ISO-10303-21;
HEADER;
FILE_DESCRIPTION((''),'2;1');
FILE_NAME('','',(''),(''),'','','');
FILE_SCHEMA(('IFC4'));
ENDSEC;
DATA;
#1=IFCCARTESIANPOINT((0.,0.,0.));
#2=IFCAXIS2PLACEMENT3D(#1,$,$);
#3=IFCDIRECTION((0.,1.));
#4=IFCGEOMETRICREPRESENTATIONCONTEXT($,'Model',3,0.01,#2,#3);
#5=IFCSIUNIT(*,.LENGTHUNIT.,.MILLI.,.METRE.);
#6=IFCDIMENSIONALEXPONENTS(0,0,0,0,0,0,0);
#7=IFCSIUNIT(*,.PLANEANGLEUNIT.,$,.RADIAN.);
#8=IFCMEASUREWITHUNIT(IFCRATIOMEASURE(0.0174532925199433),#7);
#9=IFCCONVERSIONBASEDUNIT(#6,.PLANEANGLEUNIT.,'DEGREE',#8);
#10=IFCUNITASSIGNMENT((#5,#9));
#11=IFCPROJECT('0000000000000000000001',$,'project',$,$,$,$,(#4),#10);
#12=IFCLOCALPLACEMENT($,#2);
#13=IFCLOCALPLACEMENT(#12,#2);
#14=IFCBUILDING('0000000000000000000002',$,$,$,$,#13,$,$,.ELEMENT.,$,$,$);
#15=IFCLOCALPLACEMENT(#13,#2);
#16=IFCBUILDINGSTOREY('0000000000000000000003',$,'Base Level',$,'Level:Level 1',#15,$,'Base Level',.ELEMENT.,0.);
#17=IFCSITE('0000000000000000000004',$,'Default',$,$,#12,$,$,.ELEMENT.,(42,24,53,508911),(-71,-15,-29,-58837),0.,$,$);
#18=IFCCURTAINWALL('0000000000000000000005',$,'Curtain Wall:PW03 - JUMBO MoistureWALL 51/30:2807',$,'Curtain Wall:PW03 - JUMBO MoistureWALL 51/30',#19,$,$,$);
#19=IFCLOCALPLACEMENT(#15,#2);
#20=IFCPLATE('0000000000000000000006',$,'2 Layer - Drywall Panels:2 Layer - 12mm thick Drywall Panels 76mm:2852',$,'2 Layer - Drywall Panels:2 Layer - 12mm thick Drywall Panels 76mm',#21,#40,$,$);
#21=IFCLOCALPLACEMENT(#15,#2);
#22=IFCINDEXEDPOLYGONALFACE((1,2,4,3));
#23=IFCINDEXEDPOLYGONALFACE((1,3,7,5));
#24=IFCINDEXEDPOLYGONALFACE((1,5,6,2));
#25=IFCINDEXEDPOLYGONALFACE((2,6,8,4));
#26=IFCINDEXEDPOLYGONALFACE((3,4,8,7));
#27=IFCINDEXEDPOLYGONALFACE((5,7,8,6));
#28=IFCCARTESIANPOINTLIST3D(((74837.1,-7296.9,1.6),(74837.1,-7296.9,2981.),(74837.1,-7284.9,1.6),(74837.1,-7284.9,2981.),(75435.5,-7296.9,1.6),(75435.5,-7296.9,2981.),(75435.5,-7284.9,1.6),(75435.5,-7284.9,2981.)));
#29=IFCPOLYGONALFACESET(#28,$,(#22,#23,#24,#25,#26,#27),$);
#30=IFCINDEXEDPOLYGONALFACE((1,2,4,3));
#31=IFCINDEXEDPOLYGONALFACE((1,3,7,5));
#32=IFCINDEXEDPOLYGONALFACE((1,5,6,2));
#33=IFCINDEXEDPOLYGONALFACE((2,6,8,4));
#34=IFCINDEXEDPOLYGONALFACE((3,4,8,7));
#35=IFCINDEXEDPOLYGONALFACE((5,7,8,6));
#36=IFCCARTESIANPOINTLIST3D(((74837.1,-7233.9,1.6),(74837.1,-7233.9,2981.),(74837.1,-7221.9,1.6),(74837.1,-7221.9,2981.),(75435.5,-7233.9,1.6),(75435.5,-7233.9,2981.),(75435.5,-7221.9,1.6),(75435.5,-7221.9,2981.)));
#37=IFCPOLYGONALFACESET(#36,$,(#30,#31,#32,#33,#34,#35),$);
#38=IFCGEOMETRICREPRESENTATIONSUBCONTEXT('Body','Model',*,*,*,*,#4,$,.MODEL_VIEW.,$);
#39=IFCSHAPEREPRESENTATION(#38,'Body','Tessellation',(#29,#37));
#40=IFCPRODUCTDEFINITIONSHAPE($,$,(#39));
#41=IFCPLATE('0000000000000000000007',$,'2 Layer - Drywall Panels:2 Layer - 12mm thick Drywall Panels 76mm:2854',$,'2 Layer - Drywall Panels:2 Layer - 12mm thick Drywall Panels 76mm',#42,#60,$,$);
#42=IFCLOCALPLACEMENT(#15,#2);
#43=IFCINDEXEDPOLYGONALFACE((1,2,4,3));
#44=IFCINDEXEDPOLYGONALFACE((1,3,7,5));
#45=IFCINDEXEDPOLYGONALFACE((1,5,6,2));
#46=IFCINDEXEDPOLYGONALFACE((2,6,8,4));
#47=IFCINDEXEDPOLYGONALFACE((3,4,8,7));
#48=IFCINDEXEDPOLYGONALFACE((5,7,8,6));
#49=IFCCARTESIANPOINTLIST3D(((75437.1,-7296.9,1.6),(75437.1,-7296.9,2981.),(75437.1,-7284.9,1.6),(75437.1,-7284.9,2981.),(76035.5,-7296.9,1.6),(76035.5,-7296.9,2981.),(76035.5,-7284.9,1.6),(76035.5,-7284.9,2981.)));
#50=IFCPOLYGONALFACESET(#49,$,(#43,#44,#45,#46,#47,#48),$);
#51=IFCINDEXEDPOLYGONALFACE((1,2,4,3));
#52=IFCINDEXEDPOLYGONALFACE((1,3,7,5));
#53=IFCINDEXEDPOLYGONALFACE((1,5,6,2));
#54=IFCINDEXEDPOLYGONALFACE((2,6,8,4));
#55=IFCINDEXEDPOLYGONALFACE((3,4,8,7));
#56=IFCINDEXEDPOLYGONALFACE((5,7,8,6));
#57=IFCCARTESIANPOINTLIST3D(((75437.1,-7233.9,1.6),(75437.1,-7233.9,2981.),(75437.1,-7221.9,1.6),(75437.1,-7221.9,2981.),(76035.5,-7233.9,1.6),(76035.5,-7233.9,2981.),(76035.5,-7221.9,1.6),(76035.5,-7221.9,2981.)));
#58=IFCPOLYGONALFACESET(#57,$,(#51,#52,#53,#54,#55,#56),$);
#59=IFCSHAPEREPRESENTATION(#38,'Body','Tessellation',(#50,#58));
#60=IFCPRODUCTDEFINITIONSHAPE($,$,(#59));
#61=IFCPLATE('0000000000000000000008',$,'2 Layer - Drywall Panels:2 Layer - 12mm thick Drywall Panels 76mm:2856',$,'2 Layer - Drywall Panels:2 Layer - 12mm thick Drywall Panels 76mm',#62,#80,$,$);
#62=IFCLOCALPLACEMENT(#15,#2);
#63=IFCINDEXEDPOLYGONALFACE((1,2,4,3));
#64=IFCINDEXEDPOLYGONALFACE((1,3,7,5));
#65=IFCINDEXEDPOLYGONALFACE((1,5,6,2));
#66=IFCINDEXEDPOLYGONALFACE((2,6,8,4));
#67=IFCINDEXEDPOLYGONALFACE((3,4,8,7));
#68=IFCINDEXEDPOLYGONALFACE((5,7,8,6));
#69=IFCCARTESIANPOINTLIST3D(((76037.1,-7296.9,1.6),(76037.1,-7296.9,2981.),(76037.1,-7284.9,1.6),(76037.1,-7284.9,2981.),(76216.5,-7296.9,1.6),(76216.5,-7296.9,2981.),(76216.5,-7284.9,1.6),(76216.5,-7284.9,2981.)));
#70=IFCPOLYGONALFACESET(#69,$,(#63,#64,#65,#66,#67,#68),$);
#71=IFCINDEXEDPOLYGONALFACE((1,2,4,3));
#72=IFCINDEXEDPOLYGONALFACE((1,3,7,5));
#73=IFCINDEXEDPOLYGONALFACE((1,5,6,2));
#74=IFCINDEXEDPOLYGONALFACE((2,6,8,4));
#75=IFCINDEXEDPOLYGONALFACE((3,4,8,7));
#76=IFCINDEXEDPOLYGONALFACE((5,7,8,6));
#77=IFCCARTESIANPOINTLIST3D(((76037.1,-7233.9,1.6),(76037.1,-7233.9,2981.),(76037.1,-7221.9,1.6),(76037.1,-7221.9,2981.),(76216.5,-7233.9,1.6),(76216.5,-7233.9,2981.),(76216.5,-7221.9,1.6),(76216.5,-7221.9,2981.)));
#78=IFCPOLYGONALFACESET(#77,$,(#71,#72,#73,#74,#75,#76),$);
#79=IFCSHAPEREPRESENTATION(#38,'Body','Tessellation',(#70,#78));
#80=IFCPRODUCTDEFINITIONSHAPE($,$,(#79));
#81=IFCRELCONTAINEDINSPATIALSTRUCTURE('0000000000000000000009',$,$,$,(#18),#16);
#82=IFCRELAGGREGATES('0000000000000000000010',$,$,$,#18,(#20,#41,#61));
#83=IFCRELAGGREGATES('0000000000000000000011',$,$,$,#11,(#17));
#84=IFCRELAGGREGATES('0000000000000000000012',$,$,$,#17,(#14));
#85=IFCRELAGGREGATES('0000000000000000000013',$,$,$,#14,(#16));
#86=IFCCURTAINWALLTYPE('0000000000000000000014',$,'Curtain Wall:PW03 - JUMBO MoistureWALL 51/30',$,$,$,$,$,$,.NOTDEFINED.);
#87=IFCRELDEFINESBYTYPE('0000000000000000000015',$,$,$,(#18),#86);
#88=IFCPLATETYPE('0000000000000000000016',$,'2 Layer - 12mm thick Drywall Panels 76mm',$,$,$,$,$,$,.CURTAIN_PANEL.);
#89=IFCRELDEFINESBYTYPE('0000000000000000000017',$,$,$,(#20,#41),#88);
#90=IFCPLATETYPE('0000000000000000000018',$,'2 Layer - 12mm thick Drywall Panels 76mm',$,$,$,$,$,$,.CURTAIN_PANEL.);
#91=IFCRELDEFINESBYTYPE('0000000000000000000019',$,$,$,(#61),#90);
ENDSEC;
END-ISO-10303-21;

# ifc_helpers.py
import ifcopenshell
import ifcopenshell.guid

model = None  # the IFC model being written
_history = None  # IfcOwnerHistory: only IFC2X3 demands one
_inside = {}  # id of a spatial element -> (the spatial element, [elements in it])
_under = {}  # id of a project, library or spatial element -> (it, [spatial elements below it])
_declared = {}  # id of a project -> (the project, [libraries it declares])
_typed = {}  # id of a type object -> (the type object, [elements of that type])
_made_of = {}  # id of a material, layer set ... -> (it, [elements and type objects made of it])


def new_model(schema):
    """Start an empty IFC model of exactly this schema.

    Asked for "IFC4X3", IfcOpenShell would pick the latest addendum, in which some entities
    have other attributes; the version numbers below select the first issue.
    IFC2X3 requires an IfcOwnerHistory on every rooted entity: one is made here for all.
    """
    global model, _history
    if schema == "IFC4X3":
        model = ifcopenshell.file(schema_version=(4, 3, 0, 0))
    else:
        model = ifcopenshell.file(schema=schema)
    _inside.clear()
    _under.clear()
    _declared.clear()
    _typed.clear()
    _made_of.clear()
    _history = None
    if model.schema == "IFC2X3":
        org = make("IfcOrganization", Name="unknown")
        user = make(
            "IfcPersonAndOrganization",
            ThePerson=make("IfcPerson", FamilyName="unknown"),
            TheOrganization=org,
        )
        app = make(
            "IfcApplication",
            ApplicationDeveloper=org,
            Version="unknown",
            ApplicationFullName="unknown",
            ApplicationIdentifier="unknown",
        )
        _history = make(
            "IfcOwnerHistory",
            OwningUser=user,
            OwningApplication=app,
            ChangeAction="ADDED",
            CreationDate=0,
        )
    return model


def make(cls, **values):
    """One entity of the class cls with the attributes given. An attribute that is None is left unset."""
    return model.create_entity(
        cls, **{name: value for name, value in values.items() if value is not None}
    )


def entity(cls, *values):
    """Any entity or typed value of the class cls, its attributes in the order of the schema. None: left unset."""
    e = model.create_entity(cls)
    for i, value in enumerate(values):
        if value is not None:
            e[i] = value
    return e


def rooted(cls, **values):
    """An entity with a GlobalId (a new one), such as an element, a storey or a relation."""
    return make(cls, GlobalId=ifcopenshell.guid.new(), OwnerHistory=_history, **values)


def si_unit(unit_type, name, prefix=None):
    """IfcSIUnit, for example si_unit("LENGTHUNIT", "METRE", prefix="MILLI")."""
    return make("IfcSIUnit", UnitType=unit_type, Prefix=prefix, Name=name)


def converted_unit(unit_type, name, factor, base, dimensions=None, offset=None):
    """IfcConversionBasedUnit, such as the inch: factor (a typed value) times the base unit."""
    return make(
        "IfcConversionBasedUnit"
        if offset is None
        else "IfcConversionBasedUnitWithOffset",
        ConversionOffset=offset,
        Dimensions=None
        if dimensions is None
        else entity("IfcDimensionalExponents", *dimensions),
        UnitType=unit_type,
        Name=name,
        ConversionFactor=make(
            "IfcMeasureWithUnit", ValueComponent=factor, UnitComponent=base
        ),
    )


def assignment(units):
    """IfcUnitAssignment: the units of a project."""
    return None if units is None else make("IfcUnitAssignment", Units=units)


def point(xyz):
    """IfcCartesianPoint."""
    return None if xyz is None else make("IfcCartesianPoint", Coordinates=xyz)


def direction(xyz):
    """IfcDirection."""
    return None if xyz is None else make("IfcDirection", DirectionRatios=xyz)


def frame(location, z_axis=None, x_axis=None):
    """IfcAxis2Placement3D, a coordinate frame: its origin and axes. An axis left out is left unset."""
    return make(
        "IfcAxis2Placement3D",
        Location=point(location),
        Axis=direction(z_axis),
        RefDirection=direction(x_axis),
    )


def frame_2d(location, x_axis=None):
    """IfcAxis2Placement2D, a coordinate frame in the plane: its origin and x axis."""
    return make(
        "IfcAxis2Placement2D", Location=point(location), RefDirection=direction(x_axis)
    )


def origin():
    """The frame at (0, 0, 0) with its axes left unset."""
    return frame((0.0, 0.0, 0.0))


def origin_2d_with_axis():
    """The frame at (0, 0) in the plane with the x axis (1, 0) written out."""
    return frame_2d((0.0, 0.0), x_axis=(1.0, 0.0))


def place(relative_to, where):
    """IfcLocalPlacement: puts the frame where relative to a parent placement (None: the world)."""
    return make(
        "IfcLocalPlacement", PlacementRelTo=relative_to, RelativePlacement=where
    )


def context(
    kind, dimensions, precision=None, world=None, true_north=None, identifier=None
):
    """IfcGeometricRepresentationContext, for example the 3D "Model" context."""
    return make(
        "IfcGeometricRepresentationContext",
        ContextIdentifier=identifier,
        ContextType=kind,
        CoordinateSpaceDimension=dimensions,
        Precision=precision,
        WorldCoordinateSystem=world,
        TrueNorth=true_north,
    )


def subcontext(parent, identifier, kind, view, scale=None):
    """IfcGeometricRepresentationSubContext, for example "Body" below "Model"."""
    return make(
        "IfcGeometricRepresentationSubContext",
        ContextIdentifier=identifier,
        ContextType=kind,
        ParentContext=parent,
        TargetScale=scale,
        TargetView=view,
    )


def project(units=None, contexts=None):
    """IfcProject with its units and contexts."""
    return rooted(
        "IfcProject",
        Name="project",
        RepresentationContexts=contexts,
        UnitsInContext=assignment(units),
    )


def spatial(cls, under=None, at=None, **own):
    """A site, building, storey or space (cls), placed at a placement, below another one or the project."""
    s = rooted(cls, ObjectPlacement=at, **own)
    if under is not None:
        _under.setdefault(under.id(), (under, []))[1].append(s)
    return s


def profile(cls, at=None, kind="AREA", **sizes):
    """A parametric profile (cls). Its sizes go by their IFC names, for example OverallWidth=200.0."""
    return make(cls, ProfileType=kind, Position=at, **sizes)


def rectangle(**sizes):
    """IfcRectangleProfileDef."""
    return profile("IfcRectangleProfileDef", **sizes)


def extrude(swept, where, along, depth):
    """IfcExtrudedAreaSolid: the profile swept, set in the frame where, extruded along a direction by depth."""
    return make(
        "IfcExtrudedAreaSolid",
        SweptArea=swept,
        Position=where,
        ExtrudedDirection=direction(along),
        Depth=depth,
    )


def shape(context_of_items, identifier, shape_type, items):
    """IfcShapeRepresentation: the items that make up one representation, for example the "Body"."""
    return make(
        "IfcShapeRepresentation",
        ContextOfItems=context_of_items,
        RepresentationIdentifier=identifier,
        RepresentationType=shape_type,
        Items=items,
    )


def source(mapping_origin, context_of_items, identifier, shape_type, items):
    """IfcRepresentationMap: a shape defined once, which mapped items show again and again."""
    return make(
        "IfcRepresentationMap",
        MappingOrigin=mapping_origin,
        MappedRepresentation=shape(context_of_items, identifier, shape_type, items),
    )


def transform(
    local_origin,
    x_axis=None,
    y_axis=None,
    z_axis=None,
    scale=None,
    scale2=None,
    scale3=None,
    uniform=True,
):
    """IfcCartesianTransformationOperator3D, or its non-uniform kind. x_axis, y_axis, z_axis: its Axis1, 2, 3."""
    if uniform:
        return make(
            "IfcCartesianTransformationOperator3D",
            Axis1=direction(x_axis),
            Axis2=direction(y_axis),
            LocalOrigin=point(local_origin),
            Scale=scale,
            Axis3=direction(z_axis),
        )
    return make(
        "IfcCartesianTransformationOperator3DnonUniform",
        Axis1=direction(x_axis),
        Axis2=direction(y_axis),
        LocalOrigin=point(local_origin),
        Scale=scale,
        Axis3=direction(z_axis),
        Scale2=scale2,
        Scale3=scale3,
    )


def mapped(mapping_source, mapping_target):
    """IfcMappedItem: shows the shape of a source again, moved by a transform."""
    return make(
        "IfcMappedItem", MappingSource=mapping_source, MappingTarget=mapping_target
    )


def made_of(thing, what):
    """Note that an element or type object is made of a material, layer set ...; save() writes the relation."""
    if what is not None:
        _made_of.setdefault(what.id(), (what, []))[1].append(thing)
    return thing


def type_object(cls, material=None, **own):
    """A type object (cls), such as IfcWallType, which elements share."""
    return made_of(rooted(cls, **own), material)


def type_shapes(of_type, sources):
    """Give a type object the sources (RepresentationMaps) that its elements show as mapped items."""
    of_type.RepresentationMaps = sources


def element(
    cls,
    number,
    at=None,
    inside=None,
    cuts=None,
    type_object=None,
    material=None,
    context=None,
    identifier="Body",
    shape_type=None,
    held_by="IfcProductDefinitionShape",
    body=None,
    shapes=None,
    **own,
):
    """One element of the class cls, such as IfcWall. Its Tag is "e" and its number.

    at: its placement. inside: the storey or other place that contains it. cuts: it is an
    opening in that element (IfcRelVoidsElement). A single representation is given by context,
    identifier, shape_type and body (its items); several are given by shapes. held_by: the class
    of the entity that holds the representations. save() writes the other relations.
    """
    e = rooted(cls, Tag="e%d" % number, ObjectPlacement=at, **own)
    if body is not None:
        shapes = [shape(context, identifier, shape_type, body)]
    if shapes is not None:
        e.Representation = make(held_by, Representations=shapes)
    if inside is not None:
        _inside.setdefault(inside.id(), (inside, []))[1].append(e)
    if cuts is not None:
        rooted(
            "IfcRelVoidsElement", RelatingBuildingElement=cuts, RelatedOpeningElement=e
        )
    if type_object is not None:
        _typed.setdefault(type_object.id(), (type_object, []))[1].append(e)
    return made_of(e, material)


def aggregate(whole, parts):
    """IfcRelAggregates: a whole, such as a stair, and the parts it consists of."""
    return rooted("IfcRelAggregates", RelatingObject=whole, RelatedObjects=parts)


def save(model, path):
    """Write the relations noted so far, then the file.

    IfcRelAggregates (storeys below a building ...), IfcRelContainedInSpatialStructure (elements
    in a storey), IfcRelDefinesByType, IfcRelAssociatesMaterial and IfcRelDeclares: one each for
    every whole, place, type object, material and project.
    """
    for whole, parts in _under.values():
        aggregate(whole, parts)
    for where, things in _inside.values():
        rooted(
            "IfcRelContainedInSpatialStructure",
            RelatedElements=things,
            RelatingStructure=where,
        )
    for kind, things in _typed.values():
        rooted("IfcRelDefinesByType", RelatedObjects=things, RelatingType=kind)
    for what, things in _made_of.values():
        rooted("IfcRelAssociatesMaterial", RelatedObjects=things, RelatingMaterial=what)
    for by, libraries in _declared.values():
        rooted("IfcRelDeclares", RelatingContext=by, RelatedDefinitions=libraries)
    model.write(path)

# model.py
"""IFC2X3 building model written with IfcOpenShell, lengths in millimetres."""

from ifc_helpers import new_model, entity, si_unit, converted_unit, direction, frame, frame_2d, origin, origin_2d_with_axis, place, context, subcontext, project, spatial, rectangle, extrude, source, transform, mapped, type_object, type_shapes, element, aggregate, save


model = new_model("IFC2X3")

# Units and contexts
model_context = context("Model", 3, precision=0.01, world=origin(), true_north=direction((0.0, 1.0)))
body_context = subcontext(model_context, "Body", "Model", "MODEL_VIEW")
ifc_project = project(units=[si_unit("LENGTHUNIT", "METRE", prefix="MILLI"), converted_unit("PLANEANGLEUNIT", "DEGREE", entity("IfcRatioMeasure", 0.0174532925199433), si_unit("PLANEANGLEUNIT", "RADIAN"), dimensions=[0, 0, 0, 0, 0, 0, 0])], contexts=[model_context])

# Site, building, storey
site_placement = place(None, origin())
site = spatial("IfcSite", under=ifc_project, at=site_placement, Name="Default", CompositionType="ELEMENT", RefLatitude=(42, 24, 53, 508911), RefLongitude=(-71, -15, -29, -58837), RefElevation=0.0)
building_placement = place(site_placement, origin())
building = spatial("IfcBuilding", under=site, at=building_placement, CompositionType="ELEMENT")
storey_placement = place(building_placement, origin())
storey = spatial("IfcBuildingStorey", under=building, at=storey_placement, Name="Base Level", ObjectType="Level:Level 1", LongName="Base Level", CompositionType="ELEMENT", Elevation=0.0)

# Curtain wall, plates
curtain_wall_type = type_object("IfcCurtainWallType", Name="Curtain Wall:PW03 - JUMBO MoistureWALL 51/30", PredefinedType="NOTDEFINED")
curtain_wall_placement = place(building_placement, origin())
curtain_wall = element("IfcCurtainWall", 1, at=curtain_wall_placement, inside=storey, type_object=curtain_wall_type, Name="Curtain Wall:PW03 - JUMBO MoistureWALL 51/30:2807", ObjectType="Curtain Wall:PW03 - JUMBO MoistureWALL 51/30")
plate_type_1 = type_object("IfcPlateType", Name="2 Layer - 12mm thick Drywall Panels 76mm", PredefinedType="CURTAIN_PANEL")
shared_shape_1 = source(origin(), body_context, "Body", "SweptSolid", [
    extrude(rectangle(XDim=598.4, YDim=12.0, at=origin_2d_with_axis()), frame((0.0, -31.5, 0.0), z_axis=(0.0, 0.0, 1.0), x_axis=(-1.0, 0.0, 0.0)), (0.0, 0.0, 1.0), 2979.4),
    extrude(rectangle(XDim=12.0, YDim=598.4, at=frame_2d((0.0, 0.0), x_axis=(1.0, 0.0))), frame((0.0, 31.5, 0.0), z_axis=(0.0, 0.0, 1.0), x_axis=(0.0, 1.0, 0.0)), (0.0, 0.0, 1.0), 2979.4),
])
type_shapes(plate_type_1, [shared_shape_1])
plate_1_placement = place(curtain_wall_placement, frame((75136.3, -7259.4, 1.6)))
plate_1 = element("IfcPlate", 2, at=plate_1_placement, type_object=plate_type_1, Name="2 Layer - Drywall Panels:2 Layer - 12mm thick Drywall Panels 76mm:2852", ObjectType="2 Layer - Drywall Panels:2 Layer - 12mm thick Drywall Panels 76mm", context=body_context, shape_type="MappedRepresentation", body=[
    mapped(shared_shape_1, transform((0.0, 0.0, 0.0), scale=1.0)),
])
plate_2_placement = place(curtain_wall_placement, frame((75736.3, -7259.4, 1.6)))
plate_2 = element("IfcPlate", 3, at=plate_2_placement, type_object=plate_type_1, Name="2 Layer - Drywall Panels:2 Layer - 12mm thick Drywall Panels 76mm:2854", ObjectType="2 Layer - Drywall Panels:2 Layer - 12mm thick Drywall Panels 76mm", context=body_context, shape_type="MappedRepresentation", body=[
    mapped(shared_shape_1, transform((0.0, 0.0, 0.0), scale=1.0)),
])
plate_type_2 = type_object("IfcPlateType", Name="2 Layer - 12mm thick Drywall Panels 76mm", PredefinedType="CURTAIN_PANEL")
shared_shape_2 = source(origin(), body_context, "Body", "SweptSolid", [
    extrude(rectangle(XDim=179.4, YDim=12.0, at=origin_2d_with_axis()), frame((0.0, -31.5, 0.0), z_axis=(0.0, 0.0, 1.0), x_axis=(-1.0, 0.0, 0.0)), (0.0, 0.0, 1.0), 2979.4),
    extrude(rectangle(XDim=12.0, YDim=179.4, at=frame_2d((0.0, 0.0), x_axis=(1.0, 0.0))), frame((0.0, 31.5, 0.0), z_axis=(0.0, 0.0, 1.0), x_axis=(0.0, 1.0, 0.0)), (0.0, 0.0, 1.0), 2979.4),
])
type_shapes(plate_type_2, [shared_shape_2])
plate_3_placement = place(curtain_wall_placement, frame((76126.8, -7259.4, 1.6)))
plate_3 = element("IfcPlate", 4, at=plate_3_placement, type_object=plate_type_2, Name="2 Layer - Drywall Panels:2 Layer - 12mm thick Drywall Panels 76mm:2856", ObjectType="2 Layer - Drywall Panels:2 Layer - 12mm thick Drywall Panels 76mm", context=body_context, shape_type="MappedRepresentation", body=[
    mapped(shared_shape_2, transform((0.0, 0.0, 0.0), scale=1.0)),
])
aggregate(curtain_wall, [plate_1, plate_2, plate_3])

save(model, "model.ifc")
